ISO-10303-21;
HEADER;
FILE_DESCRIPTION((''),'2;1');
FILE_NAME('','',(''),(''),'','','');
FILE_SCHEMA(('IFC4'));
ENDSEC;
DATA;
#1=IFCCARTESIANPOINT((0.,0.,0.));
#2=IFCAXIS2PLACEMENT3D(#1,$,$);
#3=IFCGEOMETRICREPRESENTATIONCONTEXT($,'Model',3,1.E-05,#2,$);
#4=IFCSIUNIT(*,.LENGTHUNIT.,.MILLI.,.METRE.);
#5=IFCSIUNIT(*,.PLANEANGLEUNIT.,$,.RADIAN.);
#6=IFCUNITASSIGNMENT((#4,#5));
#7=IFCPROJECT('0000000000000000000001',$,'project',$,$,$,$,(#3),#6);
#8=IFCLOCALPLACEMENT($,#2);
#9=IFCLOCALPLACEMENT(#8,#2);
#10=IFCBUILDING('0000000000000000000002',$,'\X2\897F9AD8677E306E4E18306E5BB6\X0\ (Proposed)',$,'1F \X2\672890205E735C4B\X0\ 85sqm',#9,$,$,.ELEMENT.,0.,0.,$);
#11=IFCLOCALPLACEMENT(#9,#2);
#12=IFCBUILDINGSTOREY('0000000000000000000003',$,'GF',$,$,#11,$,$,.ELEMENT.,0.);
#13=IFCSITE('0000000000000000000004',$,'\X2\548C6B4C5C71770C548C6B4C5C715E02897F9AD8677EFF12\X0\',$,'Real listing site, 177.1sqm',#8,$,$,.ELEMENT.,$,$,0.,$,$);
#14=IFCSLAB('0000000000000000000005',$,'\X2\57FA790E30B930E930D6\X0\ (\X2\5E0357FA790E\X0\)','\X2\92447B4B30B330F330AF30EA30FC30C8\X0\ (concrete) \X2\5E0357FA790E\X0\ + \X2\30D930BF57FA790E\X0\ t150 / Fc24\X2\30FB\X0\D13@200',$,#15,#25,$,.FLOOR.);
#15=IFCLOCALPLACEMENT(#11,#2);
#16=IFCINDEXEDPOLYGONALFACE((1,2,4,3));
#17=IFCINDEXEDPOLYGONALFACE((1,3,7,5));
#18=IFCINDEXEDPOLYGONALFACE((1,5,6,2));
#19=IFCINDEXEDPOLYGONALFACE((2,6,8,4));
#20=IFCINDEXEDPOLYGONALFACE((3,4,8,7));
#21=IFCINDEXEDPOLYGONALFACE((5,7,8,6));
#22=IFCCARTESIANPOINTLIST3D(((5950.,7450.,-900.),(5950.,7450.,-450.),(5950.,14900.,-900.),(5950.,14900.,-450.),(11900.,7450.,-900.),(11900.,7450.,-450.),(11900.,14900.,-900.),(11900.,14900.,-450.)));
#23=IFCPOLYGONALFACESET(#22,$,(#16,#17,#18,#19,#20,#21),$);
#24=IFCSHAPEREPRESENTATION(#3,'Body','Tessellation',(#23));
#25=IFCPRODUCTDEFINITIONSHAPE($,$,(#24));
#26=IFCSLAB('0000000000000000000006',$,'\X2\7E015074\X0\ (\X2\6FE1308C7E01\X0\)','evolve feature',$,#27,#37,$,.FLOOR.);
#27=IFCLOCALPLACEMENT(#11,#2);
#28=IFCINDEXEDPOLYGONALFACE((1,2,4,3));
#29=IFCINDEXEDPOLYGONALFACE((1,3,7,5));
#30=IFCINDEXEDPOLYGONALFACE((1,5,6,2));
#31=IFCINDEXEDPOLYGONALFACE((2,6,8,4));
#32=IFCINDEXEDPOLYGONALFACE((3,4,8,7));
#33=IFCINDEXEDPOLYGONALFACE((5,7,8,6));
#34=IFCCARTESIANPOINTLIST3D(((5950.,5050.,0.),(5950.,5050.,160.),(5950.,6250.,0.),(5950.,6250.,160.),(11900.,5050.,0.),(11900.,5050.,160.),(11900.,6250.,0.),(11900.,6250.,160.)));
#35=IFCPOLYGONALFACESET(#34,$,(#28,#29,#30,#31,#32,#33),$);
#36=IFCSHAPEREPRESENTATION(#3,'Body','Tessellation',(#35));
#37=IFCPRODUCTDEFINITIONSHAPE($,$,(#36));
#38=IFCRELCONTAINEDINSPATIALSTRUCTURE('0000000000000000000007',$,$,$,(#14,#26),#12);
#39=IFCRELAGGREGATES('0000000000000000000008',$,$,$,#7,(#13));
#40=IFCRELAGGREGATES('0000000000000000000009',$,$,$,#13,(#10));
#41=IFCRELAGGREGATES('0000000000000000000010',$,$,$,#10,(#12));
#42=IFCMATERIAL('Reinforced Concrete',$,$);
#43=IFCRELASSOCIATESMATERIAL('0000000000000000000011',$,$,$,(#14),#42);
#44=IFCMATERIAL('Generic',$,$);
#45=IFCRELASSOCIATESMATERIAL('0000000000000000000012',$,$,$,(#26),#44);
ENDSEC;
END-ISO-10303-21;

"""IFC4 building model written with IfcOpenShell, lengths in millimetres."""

from ifc_helpers import new_model, si_unit, frame, frame_2d, origin, place, context, project, spatial, rectangle, extrude, material, element, save


model = new_model("IFC4")

# Units and contexts
model_context = context("Model", 3, precision=1e-05, world=origin())
ifc_project = project(units=[si_unit("LENGTHUNIT", "METRE", prefix="MILLI"), si_unit("PLANEANGLEUNIT", "RADIAN")], contexts=[model_context])

# Site, building, storey
site_placement = place(None, origin())
site = spatial("IfcSite", under=ifc_project, at=site_placement, Name="和歌山県和歌山市西高松２", ObjectType="Real listing site, 177.1sqm", CompositionType="ELEMENT", RefElevation=0.0)
building_placement = place(site_placement, origin())
building = spatial("IfcBuilding", under=site, at=building_placement, Name="西高松の丘の家 (Proposed)", ObjectType="1F 木造平屋 85sqm", CompositionType="ELEMENT", ElevationOfRefHeight=0.0, ElevationOfTerrain=0.0)
storey_placement = place(building_placement, origin())
storey = spatial("IfcBuildingStorey", under=building, at=storey_placement, Name="GF", CompositionType="ELEMENT", Elevation=0.0)

# Slabs
ifc_material_1 = material(Name="Reinforced Concrete")
slab_1_placement = place(storey_placement, frame((2975.0, 3725.0, -450.0)))
element("IfcSlab", 1, at=slab_1_placement, inside=storey, material=ifc_material_1, Name="基礎スラブ (布基礎)", Description="鉄筋コンクリート (concrete) 布基礎 + ベタ基礎 t150 / Fc24・D13@200", PredefinedType="FLOOR", context=model_context, shape_type="SweptSolid", body=[
    extrude(rectangle(XDim=5950.0, YDim=7450.0, at=frame_2d((2975.0, 3725.0))), frame((2975.0, 3725.0, -450.0)), (0.0, 0.0, 1.0), 450.0),
])
ifc_material_2 = material(Name="Generic")
slab_2_placement = place(storey_placement, frame((2975.0, 2525.0, 0.0)))
element("IfcSlab", 2, at=slab_2_placement, inside=storey, material=ifc_material_2, Name="縁側 (濡れ縁)", Description="evolve feature", PredefinedType="FLOOR", context=model_context, shape_type="SweptSolid", body=[
    extrude(rectangle(XDim=5950.0, YDim=1200.0, at=frame_2d((2975.0, 600.0))), frame((2975.0, 2525.0, 0.0)), (0.0, 0.0, 1.0), 160.0),
])

save(model, "model.ifc")
